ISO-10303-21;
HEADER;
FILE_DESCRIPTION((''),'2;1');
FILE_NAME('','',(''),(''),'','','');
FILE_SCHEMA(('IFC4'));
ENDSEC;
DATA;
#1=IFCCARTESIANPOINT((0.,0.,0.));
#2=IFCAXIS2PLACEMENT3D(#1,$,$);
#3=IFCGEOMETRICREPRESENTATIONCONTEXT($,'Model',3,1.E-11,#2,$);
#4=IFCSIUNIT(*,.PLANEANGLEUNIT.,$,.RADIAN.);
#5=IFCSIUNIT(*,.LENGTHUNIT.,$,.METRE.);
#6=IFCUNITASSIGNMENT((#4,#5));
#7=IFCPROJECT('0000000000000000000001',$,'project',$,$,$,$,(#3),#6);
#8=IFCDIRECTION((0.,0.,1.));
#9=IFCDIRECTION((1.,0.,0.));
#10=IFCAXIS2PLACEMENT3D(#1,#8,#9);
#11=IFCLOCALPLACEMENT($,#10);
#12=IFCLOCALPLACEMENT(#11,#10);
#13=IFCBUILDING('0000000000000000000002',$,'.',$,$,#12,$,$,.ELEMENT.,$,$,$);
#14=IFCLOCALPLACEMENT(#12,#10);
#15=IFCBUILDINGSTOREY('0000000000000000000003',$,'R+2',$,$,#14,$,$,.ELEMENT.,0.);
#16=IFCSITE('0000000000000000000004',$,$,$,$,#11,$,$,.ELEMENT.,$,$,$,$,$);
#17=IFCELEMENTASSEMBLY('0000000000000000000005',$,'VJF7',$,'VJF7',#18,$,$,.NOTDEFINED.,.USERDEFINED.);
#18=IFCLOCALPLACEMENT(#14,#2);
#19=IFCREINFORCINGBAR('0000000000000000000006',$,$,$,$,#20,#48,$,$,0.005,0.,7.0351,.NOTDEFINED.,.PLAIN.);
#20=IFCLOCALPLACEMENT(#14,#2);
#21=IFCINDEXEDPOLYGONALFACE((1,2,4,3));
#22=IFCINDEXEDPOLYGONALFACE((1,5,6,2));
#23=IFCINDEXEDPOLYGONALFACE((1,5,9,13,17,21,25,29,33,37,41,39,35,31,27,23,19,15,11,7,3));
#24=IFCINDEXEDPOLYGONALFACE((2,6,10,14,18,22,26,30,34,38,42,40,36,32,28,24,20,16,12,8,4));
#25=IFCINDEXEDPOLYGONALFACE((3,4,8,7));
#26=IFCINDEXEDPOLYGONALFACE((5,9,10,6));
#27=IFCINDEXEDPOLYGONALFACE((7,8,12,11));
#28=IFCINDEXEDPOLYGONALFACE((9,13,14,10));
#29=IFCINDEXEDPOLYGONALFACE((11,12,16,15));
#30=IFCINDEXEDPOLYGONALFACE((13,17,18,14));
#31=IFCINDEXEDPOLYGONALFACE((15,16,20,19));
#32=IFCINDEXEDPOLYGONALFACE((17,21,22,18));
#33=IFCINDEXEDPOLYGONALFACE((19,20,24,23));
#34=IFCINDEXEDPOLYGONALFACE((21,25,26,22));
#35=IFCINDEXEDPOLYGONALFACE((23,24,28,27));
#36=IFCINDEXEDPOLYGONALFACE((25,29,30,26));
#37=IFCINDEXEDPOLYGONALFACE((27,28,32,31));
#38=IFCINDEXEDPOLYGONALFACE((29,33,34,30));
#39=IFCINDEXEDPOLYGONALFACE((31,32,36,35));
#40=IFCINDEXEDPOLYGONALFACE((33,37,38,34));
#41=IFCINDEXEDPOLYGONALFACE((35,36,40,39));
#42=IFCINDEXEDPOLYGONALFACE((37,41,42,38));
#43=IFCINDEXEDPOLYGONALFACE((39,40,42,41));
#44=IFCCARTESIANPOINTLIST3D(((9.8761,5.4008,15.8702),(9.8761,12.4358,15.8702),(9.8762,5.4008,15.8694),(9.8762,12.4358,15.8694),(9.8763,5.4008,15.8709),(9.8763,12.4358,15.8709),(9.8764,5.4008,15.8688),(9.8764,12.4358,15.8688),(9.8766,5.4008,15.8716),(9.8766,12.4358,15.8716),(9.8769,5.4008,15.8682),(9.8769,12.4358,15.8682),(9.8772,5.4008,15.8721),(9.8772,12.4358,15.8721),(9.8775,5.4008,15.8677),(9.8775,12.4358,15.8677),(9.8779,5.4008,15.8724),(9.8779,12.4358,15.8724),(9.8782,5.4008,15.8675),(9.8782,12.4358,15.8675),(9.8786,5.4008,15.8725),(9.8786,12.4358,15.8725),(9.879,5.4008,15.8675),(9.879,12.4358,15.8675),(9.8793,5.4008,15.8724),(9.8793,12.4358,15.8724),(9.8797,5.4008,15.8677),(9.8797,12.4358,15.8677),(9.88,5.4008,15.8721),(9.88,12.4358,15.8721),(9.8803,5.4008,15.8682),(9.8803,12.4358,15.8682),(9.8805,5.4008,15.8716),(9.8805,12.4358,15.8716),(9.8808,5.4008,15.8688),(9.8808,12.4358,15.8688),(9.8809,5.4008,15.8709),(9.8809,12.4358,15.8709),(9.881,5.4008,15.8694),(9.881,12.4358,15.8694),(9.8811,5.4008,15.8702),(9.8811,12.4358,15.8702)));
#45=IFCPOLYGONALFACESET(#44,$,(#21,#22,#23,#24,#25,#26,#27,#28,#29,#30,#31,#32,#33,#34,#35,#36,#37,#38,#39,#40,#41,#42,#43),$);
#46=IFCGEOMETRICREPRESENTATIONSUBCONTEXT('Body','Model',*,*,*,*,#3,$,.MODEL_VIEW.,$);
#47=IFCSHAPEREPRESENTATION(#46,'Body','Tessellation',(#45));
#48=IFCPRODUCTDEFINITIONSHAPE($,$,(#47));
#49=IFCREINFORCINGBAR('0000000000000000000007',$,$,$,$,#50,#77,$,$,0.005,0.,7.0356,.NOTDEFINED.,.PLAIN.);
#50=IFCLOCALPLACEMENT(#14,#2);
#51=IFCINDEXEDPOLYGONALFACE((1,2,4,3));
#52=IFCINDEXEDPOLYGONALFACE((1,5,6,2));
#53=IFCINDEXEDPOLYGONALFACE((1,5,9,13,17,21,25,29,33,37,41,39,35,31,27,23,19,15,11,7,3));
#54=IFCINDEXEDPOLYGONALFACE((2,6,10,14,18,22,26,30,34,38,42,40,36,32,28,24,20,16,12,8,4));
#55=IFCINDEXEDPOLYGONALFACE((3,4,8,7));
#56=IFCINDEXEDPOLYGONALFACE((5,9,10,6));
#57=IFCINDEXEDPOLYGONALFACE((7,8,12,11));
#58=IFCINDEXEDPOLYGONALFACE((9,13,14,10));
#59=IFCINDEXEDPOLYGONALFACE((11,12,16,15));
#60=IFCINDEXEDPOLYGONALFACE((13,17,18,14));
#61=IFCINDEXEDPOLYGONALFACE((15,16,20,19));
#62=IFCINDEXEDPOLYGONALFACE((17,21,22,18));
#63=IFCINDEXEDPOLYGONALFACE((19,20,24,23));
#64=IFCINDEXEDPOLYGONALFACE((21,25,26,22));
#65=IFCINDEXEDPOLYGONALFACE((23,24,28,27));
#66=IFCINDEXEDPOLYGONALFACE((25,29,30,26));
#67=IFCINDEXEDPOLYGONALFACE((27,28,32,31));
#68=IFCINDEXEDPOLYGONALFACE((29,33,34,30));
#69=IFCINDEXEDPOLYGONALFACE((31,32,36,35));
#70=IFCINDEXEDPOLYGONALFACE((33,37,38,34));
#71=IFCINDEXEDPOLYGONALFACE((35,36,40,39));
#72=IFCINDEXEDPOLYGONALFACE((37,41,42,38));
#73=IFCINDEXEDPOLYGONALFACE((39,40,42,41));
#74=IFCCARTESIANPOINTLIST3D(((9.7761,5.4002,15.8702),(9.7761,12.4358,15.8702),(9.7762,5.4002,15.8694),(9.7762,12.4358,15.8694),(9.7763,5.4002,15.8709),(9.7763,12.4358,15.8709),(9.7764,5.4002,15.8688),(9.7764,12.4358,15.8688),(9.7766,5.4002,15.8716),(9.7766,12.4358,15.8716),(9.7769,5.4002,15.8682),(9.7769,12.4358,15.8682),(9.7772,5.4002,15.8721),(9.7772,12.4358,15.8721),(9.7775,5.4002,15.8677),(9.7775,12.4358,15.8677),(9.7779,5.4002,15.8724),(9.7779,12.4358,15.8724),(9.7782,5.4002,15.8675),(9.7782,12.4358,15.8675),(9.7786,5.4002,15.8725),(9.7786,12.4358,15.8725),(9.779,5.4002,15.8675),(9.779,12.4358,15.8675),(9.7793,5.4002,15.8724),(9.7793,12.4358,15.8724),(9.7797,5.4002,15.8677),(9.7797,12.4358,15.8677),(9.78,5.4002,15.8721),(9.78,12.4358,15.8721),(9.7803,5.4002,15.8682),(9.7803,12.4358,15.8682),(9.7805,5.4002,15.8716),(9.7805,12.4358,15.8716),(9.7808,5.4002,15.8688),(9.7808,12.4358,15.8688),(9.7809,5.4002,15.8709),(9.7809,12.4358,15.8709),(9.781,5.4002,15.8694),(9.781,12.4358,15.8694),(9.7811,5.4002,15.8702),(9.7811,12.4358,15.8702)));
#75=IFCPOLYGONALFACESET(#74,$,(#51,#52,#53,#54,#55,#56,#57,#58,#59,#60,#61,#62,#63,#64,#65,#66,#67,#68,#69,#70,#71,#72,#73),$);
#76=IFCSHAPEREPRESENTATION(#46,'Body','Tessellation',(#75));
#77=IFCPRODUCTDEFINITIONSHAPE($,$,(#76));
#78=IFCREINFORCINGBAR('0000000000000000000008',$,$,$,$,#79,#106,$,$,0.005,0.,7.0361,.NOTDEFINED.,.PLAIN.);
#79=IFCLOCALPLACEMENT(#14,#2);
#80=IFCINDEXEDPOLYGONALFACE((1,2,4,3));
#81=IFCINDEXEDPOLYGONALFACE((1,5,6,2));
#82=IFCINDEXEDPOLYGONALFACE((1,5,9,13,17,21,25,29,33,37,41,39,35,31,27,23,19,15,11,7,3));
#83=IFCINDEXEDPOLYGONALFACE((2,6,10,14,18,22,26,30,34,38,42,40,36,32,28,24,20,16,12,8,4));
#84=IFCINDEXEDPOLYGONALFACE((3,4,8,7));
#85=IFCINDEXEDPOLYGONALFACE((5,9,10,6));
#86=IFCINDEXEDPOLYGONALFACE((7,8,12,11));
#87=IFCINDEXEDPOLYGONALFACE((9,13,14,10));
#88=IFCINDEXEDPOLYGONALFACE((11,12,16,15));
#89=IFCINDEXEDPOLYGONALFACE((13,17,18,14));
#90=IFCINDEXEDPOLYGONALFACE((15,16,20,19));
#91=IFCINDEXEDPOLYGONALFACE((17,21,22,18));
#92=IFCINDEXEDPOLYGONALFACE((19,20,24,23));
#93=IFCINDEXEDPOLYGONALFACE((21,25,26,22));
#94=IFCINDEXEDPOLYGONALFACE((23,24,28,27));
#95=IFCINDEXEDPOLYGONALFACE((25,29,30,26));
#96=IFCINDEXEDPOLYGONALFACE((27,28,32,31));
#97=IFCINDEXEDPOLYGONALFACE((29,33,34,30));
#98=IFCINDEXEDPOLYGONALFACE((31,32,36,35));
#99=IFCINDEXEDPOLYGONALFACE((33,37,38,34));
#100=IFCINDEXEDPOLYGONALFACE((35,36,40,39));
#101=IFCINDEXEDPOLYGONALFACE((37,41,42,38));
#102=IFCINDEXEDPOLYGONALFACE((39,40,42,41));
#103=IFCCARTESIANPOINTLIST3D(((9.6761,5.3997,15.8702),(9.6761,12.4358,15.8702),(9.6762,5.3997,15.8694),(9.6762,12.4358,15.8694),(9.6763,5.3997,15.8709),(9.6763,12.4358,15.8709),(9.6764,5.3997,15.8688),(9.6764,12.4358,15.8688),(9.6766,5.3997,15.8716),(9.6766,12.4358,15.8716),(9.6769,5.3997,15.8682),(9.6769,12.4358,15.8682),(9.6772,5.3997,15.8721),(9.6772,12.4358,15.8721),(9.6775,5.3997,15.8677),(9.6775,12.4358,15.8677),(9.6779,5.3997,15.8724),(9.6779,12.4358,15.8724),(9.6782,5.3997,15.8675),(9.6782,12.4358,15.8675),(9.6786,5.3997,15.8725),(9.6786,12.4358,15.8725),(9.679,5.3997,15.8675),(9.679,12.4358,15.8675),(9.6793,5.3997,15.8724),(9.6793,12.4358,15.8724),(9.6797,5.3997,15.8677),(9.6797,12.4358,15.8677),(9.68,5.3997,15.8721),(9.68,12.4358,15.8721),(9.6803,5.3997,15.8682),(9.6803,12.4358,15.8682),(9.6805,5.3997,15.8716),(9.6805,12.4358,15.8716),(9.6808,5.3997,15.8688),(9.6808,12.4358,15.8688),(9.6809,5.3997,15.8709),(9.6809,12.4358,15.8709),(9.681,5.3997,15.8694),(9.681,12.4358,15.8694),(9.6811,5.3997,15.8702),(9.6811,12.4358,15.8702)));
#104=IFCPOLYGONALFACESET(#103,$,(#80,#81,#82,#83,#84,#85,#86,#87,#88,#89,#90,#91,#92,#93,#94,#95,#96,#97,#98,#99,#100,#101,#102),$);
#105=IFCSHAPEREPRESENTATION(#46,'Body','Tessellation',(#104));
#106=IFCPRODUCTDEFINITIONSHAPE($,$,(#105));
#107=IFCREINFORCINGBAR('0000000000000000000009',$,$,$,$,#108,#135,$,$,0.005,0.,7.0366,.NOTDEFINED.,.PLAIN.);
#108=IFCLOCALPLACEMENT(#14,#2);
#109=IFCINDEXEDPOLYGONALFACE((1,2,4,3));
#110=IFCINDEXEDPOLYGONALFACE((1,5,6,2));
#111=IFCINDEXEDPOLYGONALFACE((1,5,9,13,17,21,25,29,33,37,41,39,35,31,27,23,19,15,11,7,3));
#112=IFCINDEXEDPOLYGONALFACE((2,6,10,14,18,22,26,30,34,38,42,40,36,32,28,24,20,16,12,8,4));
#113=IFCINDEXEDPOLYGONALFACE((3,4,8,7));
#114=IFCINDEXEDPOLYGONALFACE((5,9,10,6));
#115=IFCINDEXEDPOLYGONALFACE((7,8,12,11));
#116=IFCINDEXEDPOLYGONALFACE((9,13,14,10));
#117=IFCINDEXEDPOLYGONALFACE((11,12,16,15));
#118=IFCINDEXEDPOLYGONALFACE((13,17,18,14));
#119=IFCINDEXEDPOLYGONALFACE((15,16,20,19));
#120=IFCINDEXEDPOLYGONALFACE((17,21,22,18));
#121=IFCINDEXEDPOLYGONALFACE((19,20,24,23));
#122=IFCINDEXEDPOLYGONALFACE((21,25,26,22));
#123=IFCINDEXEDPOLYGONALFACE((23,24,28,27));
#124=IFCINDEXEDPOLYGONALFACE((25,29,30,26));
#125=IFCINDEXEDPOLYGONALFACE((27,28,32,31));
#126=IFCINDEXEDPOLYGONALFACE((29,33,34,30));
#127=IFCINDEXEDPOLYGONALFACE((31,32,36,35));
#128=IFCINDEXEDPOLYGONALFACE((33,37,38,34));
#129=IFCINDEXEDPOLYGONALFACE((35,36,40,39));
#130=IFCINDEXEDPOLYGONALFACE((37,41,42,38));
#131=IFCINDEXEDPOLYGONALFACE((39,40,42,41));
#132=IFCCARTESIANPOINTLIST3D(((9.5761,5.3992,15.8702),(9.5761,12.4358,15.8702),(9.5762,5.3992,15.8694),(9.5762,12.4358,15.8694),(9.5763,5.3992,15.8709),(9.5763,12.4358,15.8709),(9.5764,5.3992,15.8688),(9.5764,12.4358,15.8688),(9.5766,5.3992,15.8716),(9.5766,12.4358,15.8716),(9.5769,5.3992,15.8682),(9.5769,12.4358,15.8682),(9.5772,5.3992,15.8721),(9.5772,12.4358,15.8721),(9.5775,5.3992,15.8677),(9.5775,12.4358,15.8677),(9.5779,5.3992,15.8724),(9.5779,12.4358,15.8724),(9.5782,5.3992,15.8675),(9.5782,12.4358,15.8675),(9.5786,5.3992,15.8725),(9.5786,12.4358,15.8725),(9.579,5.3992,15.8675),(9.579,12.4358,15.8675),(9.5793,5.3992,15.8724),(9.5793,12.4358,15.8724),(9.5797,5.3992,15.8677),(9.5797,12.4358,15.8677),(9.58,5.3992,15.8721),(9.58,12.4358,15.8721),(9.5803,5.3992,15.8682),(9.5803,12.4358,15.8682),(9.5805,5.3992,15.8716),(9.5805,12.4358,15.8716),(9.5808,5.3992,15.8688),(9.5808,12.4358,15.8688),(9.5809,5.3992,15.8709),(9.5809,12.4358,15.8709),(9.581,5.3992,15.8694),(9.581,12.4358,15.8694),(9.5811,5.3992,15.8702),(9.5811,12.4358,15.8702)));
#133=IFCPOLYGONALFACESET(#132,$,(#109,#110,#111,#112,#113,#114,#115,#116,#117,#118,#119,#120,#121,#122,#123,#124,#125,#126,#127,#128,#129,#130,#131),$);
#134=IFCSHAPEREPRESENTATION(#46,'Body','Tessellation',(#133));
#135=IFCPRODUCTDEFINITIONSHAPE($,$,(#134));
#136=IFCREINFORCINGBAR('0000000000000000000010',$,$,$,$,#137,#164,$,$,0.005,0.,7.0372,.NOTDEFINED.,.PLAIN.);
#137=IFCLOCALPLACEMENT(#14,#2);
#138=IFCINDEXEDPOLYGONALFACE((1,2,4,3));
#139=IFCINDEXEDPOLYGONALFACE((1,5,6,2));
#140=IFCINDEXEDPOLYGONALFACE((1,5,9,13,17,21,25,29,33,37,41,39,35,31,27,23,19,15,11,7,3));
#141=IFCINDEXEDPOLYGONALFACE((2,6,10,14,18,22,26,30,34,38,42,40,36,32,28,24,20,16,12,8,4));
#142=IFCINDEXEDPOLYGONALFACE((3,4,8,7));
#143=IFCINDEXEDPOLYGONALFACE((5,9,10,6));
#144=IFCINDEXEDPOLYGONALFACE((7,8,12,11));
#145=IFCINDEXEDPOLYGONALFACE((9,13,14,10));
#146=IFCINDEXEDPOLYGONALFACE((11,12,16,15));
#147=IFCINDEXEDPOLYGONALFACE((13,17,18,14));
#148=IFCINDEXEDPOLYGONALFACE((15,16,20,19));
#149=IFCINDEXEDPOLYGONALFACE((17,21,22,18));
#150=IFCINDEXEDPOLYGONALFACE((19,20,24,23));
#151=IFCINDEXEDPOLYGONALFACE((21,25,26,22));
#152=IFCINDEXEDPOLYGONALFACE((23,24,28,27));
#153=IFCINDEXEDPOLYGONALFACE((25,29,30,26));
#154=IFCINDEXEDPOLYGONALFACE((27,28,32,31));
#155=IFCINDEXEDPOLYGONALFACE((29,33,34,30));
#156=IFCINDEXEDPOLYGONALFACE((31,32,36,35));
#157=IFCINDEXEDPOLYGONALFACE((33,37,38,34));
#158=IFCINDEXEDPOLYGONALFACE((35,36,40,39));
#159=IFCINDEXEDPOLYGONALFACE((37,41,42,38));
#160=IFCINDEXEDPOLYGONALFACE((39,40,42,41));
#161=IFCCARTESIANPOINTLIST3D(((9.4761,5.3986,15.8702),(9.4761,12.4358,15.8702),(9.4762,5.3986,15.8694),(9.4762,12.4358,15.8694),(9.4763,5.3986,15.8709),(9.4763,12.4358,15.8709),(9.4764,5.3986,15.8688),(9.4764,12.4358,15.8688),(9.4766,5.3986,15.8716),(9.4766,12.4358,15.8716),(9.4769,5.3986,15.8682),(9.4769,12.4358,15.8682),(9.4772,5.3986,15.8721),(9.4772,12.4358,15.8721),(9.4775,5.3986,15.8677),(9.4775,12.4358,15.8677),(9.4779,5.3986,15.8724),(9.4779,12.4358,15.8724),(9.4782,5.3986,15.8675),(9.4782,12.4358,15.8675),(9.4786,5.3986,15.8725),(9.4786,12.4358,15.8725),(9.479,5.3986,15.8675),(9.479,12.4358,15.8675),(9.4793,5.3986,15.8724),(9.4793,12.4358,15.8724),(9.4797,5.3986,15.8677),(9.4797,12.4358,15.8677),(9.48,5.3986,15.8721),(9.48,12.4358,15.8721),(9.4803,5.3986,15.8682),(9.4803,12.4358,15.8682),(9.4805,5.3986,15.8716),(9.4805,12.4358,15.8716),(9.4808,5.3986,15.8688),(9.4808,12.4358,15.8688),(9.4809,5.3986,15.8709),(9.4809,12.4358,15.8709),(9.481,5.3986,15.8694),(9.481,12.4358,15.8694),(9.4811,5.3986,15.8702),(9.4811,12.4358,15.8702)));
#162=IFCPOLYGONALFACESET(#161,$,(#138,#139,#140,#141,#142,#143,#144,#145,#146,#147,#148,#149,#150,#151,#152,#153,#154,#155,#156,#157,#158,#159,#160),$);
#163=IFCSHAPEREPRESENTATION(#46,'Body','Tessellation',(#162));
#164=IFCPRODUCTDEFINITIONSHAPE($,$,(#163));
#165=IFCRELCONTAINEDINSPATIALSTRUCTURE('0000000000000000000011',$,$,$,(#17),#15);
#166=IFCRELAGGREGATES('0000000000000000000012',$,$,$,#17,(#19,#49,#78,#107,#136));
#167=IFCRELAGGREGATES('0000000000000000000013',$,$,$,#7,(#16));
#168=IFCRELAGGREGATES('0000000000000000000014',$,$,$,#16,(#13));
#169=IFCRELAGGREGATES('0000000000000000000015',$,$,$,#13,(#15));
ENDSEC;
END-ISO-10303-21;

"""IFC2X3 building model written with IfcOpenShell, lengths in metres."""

from ifc_helpers import new_model, entity, si_unit, origin, origin_with_axes, place, context, subcontext, project, spatial, shape, element, aggregate, save


model = new_model("IFC2X3")

# Units and contexts
model_context = context("Model", 3, precision=1e-11, world=origin())
body_context = subcontext(model_context, "Body", "Model", "MODEL_VIEW")
ifc_project = project(units=[si_unit("PLANEANGLEUNIT", "RADIAN"), si_unit("LENGTHUNIT", "METRE")], contexts=[model_context])

# Site, building, storey
site_placement = place(None, origin_with_axes())
site = spatial("IfcSite", under=ifc_project, at=site_placement, CompositionType="ELEMENT")
building_placement = place(site_placement, origin_with_axes())
building = spatial("IfcBuilding", under=site, at=building_placement, Name=".", CompositionType="ELEMENT")
storey_placement = place(building_placement, origin_with_axes())
storey = spatial("IfcBuildingStorey", under=building, at=storey_placement, Name="R+2", CompositionType="ELEMENT", Elevation=0.0)

# Element assembly, reinforcing bars
assembly_1_placement = place(storey_placement, origin_with_axes())
assembly_1 = element("IfcElementAssembly", 1, at=assembly_1_placement, inside=storey, Name="VJF7", ObjectType="VJF7", AssemblyPlace="NOTDEFINED", PredefinedType="USERDEFINED")
reinforcing_bar_1_placement = place(assembly_1_placement, origin_with_axes())
reinforcing_bar_1 = element("IfcReinforcingBar", 2, at=reinforcing_bar_1_placement, BarLength=7.0351, BarRole="NOTDEFINED", BarSurface="PLAIN", CrossSectionArea=0.0, NominalDiameter=0.005, shapes=[
    shape(body_context, "Body", "AdvancedSweptSolid", [entity("IfcSweptDiskSolid", entity("IfcPolyline", [entity("IfcCartesianPoint", [9.8786, 5.4008, 15.87]), entity("IfcCartesianPoint", [9.8786, 12.4358, 15.87])]), 0.0025, None, 0.0, 7.0351)]),
    shape(body_context, "Body", "AdvancedSweptSolid", [entity("IfcSweptDiskSolid", entity("IfcPolyline", [entity("IfcCartesianPoint", [9.8786, 5.4008, 15.87]), entity("IfcCartesianPoint", [9.8786, 12.4358, 15.87])]), 0.0025, None, 0.0, 7.0351)]),
])
reinforcing_bar_2_placement = place(assembly_1_placement, origin_with_axes())
reinforcing_bar_2 = element("IfcReinforcingBar", 3, at=reinforcing_bar_2_placement, BarLength=7.0356, BarRole="NOTDEFINED", BarSurface="PLAIN", CrossSectionArea=0.0, NominalDiameter=0.005, shapes=[
    shape(body_context, "Body", "AdvancedSweptSolid", [entity("IfcSweptDiskSolid", entity("IfcPolyline", [entity("IfcCartesianPoint", [9.7786, 5.4002, 15.87]), entity("IfcCartesianPoint", [9.7786, 12.4358, 15.87])]), 0.0025, None, 0.0, 7.0356)]),
    shape(body_context, "Body", "AdvancedSweptSolid", [entity("IfcSweptDiskSolid", entity("IfcPolyline", [entity("IfcCartesianPoint", [9.7786, 5.4002, 15.87]), entity("IfcCartesianPoint", [9.7786, 12.4358, 15.87])]), 0.0025, None, 0.0, 7.0356)]),
])
reinforcing_bar_3_placement = place(assembly_1_placement, origin_with_axes())
reinforcing_bar_3 = element("IfcReinforcingBar", 4, at=reinforcing_bar_3_placement, BarLength=7.0361, BarRole="NOTDEFINED", BarSurface="PLAIN", CrossSectionArea=0.0, NominalDiameter=0.005, shapes=[
    shape(body_context, "Body", "AdvancedSweptSolid", [entity("IfcSweptDiskSolid", entity("IfcPolyline", [entity("IfcCartesianPoint", [9.6786, 5.3997, 15.87]), entity("IfcCartesianPoint", [9.6786, 12.4358, 15.87])]), 0.0025, None, 0.0, 7.0361)]),
    shape(body_context, "Body", "AdvancedSweptSolid", [entity("IfcSweptDiskSolid", entity("IfcPolyline", [entity("IfcCartesianPoint", [9.6786, 5.3997, 15.87]), entity("IfcCartesianPoint", [9.6786, 12.4358, 15.87])]), 0.0025, None, 0.0, 7.0361)]),
])
reinforcing_bar_4_placement = place(assembly_1_placement, origin_with_axes())
reinforcing_bar_4 = element("IfcReinforcingBar", 5, at=reinforcing_bar_4_placement, BarLength=7.0366, BarRole="NOTDEFINED", BarSurface="PLAIN", CrossSectionArea=0.0, NominalDiameter=0.005, shapes=[
    shape(body_context, "Body", "AdvancedSweptSolid", [entity("IfcSweptDiskSolid", entity("IfcPolyline", [entity("IfcCartesianPoint", [9.5786, 5.3992, 15.87]), entity("IfcCartesianPoint", [9.5786, 12.4358, 15.87])]), 0.0025, None, 0.0, 7.0366)]),
    shape(body_context, "Body", "AdvancedSweptSolid", [entity("IfcSweptDiskSolid", entity("IfcPolyline", [entity("IfcCartesianPoint", [9.5786, 5.3992, 15.87]), entity("IfcCartesianPoint", [9.5786, 12.4358, 15.87])]), 0.0025, None, 0.0, 7.0366)]),
])
reinforcing_bar_5_placement = place(assembly_1_placement, origin_with_axes())
reinforcing_bar_5 = element("IfcReinforcingBar", 6, at=reinforcing_bar_5_placement, BarLength=7.0372, BarRole="NOTDEFINED", BarSurface="PLAIN", CrossSectionArea=0.0, NominalDiameter=0.005, shapes=[
    shape(body_context, "Body", "AdvancedSweptSolid", [entity("IfcSweptDiskSolid", entity("IfcPolyline", [entity("IfcCartesianPoint", [9.4786, 5.3986, 15.87]), entity("IfcCartesianPoint", [9.4786, 12.4358, 15.87])]), 0.0025, None, 0.0, 7.0372)]),
    shape(body_context, "Body", "AdvancedSweptSolid", [entity("IfcSweptDiskSolid", entity("IfcPolyline", [entity("IfcCartesianPoint", [9.4786, 5.3986, 15.87]), entity("IfcCartesianPoint", [9.4786, 12.4358, 15.87])]), 0.0025, None, 0.0, 7.0372)]),
])
aggregate(assembly_1, [reinforcing_bar_1, reinforcing_bar_2, reinforcing_bar_3, reinforcing_bar_4, reinforcing_bar_5])

save(model, "model.ifc")
